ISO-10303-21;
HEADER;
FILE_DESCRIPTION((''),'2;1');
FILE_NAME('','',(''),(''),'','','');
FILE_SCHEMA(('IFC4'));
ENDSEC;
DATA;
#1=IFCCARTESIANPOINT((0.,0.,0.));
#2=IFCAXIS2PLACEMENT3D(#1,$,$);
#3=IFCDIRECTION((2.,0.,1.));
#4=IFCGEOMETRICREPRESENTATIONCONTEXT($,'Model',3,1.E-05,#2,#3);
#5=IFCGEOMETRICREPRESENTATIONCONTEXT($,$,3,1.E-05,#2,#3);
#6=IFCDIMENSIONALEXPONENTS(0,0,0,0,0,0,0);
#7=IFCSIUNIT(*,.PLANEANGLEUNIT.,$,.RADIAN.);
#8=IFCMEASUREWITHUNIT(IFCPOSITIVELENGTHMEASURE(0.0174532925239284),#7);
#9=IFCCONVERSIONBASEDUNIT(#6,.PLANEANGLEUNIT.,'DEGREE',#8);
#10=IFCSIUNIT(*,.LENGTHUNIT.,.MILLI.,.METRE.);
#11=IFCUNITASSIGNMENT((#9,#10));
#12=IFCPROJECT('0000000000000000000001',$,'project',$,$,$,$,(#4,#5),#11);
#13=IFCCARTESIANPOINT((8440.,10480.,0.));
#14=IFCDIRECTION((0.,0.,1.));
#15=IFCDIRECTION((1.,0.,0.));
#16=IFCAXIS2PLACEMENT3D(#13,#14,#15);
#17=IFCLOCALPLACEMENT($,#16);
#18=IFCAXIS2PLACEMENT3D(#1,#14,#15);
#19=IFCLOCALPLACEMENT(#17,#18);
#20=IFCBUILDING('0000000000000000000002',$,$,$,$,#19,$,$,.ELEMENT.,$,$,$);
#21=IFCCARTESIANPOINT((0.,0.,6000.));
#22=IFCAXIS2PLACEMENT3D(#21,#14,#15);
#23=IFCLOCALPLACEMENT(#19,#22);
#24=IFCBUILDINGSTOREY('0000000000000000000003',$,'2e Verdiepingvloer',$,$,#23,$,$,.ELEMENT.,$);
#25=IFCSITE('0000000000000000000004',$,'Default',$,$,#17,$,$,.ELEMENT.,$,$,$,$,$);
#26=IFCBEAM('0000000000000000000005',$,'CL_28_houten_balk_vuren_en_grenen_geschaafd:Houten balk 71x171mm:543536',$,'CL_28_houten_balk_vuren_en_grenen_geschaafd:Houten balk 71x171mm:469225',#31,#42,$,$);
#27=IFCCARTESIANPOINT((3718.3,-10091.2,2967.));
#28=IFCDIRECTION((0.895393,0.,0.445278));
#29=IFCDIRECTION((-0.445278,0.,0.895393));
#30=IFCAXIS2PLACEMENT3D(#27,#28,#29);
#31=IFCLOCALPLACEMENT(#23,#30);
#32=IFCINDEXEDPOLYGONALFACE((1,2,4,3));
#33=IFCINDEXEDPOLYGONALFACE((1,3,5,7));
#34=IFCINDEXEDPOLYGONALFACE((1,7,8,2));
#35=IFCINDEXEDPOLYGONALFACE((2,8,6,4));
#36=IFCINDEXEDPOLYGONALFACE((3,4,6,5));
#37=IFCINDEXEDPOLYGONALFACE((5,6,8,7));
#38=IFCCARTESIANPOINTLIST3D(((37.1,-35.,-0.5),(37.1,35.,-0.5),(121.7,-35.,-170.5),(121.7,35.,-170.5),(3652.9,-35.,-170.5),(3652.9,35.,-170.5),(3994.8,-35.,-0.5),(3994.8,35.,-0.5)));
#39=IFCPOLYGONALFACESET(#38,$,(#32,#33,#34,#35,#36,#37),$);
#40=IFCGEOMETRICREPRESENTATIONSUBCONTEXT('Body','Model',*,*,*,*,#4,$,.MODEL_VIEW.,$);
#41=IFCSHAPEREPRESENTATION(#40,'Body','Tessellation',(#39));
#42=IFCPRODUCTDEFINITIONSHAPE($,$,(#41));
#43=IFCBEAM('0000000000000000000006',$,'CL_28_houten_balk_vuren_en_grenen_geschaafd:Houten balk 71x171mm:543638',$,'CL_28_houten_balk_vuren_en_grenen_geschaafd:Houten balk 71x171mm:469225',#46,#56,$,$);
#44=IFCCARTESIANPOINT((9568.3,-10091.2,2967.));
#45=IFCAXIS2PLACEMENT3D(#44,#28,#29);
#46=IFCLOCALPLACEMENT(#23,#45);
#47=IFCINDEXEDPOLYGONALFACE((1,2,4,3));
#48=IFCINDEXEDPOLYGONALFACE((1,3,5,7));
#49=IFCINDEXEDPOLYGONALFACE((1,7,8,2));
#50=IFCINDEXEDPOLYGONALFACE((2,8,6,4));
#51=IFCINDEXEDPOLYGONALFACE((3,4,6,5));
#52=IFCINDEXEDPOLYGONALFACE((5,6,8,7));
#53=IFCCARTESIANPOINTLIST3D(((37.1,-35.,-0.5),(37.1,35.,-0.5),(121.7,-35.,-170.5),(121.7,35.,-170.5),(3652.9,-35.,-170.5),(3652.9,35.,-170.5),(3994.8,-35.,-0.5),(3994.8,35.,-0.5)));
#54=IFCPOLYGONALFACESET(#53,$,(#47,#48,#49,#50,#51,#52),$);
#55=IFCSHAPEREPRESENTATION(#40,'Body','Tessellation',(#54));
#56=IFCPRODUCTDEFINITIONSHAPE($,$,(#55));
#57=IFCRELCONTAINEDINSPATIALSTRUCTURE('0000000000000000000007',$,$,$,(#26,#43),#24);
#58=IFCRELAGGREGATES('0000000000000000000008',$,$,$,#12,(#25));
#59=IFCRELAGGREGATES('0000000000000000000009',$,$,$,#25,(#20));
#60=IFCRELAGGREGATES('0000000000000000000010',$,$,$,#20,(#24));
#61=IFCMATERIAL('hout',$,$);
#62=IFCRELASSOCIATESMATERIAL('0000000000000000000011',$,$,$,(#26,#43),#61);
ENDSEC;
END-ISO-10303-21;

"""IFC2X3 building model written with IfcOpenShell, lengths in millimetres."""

from ifc_helpers import new_model, entity, si_unit, converted_unit, direction, frame, frame_2d, origin, origin_with_axes, place, context, subcontext, project, spatial, rectangle, extrude, clip, halfspace, source, transform, mapped, material, element, save


model = new_model("IFC2X3")

# Units and contexts
model_context = context("Model", 3, precision=1e-05, world=origin(), true_north=direction((2.0, 0.0, 1.0)))
context_of_model = context(None, 3, precision=1e-05, world=origin(), true_north=direction((2.0, 0.0, 1.0)))
body_context = subcontext(model_context, "Body", "Model", "MODEL_VIEW")
ifc_project = project(units=[converted_unit("PLANEANGLEUNIT", "DEGREE", entity("IfcPositiveLengthMeasure", 0.0174532925239284), si_unit("PLANEANGLEUNIT", "RADIAN"), dimensions=[0, 0, 0, 0, 0, 0, 0]), si_unit("LENGTHUNIT", "METRE", prefix="MILLI")], contexts=[model_context, context_of_model])

# Site, building, storey
site_placement = place(None, frame((8440.0, 10480.0, 0.0), z_axis=(0.0, 0.0, 1.0), x_axis=(1.0, 0.0, 0.0)))
site = spatial("IfcSite", under=ifc_project, at=site_placement, Name="Default", CompositionType="ELEMENT")
building_placement = place(site_placement, origin_with_axes())
building = spatial("IfcBuilding", under=site, at=building_placement, CompositionType="ELEMENT")
storey_placement = place(building_placement, frame((0.0, 0.0, 6000.0), z_axis=(0.0, 0.0, 1.0), x_axis=(1.0, 0.0, 0.0)))
storey = spatial("IfcBuildingStorey", under=building, at=storey_placement, Name="2e Verdiepingvloer", CompositionType="ELEMENT")

# Beams
ifc_material_1 = material(Name="hout")
shared_shape_1 = source(origin(), body_context, "Body", "Clipping", [
    clip(clip(extrude(rectangle(XDim=170.0, YDim=70.0, at=frame_2d((0.0, 0.0), x_axis=(1.0, 0.0))), frame((37.1, 0.0, -85.5), z_axis=(1.0, 0.0, 0.0), x_axis=(0.0, 0.0, -1.0)), (0.0, 0.0, 1.0), 3957.7), halfspace(frame((3651.9, 0.0, -171.0), z_axis=(0.445278, 0.0, -0.895393), x_axis=(0.0, 1.0, 0.0)), False)), halfspace(frame((-9522.9, -1.8, 19223.4), z_axis=(-0.895393, 0.0, -0.445278), x_axis=(0.445278, 0.0, -0.895393)), False)),
])
for number, where, z_axis, x_axis, name in (
    (1, (3718.3, -10091.2, 2967.0), (0.895393, 0.0, 0.445278), (-0.445278, 0.0, 0.895393), "CL_28_houten_balk_vuren_en_grenen_geschaafd:Houten balk 71x171mm:543536"),
    (2, (9568.3, -10091.2, 2967.0), (0.895393, 0.0, 0.445278), (-0.445278, 0.0, 0.895393), "CL_28_houten_balk_vuren_en_grenen_geschaafd:Houten balk 71x171mm:543638"),
):
    element("IfcBeam", number, at=place(storey_placement, frame(where, z_axis=z_axis, x_axis=x_axis)), inside=storey, material=ifc_material_1, Name=name, ObjectType="CL_28_houten_balk_vuren_en_grenen_geschaafd:Houten balk 71x171mm:469225", context=body_context, shape_type="MappedRepresentation", body=[
        mapped(shared_shape_1, transform((0.0, 0.0, 0.0))),
    ])

save(model, "model.ifc")
